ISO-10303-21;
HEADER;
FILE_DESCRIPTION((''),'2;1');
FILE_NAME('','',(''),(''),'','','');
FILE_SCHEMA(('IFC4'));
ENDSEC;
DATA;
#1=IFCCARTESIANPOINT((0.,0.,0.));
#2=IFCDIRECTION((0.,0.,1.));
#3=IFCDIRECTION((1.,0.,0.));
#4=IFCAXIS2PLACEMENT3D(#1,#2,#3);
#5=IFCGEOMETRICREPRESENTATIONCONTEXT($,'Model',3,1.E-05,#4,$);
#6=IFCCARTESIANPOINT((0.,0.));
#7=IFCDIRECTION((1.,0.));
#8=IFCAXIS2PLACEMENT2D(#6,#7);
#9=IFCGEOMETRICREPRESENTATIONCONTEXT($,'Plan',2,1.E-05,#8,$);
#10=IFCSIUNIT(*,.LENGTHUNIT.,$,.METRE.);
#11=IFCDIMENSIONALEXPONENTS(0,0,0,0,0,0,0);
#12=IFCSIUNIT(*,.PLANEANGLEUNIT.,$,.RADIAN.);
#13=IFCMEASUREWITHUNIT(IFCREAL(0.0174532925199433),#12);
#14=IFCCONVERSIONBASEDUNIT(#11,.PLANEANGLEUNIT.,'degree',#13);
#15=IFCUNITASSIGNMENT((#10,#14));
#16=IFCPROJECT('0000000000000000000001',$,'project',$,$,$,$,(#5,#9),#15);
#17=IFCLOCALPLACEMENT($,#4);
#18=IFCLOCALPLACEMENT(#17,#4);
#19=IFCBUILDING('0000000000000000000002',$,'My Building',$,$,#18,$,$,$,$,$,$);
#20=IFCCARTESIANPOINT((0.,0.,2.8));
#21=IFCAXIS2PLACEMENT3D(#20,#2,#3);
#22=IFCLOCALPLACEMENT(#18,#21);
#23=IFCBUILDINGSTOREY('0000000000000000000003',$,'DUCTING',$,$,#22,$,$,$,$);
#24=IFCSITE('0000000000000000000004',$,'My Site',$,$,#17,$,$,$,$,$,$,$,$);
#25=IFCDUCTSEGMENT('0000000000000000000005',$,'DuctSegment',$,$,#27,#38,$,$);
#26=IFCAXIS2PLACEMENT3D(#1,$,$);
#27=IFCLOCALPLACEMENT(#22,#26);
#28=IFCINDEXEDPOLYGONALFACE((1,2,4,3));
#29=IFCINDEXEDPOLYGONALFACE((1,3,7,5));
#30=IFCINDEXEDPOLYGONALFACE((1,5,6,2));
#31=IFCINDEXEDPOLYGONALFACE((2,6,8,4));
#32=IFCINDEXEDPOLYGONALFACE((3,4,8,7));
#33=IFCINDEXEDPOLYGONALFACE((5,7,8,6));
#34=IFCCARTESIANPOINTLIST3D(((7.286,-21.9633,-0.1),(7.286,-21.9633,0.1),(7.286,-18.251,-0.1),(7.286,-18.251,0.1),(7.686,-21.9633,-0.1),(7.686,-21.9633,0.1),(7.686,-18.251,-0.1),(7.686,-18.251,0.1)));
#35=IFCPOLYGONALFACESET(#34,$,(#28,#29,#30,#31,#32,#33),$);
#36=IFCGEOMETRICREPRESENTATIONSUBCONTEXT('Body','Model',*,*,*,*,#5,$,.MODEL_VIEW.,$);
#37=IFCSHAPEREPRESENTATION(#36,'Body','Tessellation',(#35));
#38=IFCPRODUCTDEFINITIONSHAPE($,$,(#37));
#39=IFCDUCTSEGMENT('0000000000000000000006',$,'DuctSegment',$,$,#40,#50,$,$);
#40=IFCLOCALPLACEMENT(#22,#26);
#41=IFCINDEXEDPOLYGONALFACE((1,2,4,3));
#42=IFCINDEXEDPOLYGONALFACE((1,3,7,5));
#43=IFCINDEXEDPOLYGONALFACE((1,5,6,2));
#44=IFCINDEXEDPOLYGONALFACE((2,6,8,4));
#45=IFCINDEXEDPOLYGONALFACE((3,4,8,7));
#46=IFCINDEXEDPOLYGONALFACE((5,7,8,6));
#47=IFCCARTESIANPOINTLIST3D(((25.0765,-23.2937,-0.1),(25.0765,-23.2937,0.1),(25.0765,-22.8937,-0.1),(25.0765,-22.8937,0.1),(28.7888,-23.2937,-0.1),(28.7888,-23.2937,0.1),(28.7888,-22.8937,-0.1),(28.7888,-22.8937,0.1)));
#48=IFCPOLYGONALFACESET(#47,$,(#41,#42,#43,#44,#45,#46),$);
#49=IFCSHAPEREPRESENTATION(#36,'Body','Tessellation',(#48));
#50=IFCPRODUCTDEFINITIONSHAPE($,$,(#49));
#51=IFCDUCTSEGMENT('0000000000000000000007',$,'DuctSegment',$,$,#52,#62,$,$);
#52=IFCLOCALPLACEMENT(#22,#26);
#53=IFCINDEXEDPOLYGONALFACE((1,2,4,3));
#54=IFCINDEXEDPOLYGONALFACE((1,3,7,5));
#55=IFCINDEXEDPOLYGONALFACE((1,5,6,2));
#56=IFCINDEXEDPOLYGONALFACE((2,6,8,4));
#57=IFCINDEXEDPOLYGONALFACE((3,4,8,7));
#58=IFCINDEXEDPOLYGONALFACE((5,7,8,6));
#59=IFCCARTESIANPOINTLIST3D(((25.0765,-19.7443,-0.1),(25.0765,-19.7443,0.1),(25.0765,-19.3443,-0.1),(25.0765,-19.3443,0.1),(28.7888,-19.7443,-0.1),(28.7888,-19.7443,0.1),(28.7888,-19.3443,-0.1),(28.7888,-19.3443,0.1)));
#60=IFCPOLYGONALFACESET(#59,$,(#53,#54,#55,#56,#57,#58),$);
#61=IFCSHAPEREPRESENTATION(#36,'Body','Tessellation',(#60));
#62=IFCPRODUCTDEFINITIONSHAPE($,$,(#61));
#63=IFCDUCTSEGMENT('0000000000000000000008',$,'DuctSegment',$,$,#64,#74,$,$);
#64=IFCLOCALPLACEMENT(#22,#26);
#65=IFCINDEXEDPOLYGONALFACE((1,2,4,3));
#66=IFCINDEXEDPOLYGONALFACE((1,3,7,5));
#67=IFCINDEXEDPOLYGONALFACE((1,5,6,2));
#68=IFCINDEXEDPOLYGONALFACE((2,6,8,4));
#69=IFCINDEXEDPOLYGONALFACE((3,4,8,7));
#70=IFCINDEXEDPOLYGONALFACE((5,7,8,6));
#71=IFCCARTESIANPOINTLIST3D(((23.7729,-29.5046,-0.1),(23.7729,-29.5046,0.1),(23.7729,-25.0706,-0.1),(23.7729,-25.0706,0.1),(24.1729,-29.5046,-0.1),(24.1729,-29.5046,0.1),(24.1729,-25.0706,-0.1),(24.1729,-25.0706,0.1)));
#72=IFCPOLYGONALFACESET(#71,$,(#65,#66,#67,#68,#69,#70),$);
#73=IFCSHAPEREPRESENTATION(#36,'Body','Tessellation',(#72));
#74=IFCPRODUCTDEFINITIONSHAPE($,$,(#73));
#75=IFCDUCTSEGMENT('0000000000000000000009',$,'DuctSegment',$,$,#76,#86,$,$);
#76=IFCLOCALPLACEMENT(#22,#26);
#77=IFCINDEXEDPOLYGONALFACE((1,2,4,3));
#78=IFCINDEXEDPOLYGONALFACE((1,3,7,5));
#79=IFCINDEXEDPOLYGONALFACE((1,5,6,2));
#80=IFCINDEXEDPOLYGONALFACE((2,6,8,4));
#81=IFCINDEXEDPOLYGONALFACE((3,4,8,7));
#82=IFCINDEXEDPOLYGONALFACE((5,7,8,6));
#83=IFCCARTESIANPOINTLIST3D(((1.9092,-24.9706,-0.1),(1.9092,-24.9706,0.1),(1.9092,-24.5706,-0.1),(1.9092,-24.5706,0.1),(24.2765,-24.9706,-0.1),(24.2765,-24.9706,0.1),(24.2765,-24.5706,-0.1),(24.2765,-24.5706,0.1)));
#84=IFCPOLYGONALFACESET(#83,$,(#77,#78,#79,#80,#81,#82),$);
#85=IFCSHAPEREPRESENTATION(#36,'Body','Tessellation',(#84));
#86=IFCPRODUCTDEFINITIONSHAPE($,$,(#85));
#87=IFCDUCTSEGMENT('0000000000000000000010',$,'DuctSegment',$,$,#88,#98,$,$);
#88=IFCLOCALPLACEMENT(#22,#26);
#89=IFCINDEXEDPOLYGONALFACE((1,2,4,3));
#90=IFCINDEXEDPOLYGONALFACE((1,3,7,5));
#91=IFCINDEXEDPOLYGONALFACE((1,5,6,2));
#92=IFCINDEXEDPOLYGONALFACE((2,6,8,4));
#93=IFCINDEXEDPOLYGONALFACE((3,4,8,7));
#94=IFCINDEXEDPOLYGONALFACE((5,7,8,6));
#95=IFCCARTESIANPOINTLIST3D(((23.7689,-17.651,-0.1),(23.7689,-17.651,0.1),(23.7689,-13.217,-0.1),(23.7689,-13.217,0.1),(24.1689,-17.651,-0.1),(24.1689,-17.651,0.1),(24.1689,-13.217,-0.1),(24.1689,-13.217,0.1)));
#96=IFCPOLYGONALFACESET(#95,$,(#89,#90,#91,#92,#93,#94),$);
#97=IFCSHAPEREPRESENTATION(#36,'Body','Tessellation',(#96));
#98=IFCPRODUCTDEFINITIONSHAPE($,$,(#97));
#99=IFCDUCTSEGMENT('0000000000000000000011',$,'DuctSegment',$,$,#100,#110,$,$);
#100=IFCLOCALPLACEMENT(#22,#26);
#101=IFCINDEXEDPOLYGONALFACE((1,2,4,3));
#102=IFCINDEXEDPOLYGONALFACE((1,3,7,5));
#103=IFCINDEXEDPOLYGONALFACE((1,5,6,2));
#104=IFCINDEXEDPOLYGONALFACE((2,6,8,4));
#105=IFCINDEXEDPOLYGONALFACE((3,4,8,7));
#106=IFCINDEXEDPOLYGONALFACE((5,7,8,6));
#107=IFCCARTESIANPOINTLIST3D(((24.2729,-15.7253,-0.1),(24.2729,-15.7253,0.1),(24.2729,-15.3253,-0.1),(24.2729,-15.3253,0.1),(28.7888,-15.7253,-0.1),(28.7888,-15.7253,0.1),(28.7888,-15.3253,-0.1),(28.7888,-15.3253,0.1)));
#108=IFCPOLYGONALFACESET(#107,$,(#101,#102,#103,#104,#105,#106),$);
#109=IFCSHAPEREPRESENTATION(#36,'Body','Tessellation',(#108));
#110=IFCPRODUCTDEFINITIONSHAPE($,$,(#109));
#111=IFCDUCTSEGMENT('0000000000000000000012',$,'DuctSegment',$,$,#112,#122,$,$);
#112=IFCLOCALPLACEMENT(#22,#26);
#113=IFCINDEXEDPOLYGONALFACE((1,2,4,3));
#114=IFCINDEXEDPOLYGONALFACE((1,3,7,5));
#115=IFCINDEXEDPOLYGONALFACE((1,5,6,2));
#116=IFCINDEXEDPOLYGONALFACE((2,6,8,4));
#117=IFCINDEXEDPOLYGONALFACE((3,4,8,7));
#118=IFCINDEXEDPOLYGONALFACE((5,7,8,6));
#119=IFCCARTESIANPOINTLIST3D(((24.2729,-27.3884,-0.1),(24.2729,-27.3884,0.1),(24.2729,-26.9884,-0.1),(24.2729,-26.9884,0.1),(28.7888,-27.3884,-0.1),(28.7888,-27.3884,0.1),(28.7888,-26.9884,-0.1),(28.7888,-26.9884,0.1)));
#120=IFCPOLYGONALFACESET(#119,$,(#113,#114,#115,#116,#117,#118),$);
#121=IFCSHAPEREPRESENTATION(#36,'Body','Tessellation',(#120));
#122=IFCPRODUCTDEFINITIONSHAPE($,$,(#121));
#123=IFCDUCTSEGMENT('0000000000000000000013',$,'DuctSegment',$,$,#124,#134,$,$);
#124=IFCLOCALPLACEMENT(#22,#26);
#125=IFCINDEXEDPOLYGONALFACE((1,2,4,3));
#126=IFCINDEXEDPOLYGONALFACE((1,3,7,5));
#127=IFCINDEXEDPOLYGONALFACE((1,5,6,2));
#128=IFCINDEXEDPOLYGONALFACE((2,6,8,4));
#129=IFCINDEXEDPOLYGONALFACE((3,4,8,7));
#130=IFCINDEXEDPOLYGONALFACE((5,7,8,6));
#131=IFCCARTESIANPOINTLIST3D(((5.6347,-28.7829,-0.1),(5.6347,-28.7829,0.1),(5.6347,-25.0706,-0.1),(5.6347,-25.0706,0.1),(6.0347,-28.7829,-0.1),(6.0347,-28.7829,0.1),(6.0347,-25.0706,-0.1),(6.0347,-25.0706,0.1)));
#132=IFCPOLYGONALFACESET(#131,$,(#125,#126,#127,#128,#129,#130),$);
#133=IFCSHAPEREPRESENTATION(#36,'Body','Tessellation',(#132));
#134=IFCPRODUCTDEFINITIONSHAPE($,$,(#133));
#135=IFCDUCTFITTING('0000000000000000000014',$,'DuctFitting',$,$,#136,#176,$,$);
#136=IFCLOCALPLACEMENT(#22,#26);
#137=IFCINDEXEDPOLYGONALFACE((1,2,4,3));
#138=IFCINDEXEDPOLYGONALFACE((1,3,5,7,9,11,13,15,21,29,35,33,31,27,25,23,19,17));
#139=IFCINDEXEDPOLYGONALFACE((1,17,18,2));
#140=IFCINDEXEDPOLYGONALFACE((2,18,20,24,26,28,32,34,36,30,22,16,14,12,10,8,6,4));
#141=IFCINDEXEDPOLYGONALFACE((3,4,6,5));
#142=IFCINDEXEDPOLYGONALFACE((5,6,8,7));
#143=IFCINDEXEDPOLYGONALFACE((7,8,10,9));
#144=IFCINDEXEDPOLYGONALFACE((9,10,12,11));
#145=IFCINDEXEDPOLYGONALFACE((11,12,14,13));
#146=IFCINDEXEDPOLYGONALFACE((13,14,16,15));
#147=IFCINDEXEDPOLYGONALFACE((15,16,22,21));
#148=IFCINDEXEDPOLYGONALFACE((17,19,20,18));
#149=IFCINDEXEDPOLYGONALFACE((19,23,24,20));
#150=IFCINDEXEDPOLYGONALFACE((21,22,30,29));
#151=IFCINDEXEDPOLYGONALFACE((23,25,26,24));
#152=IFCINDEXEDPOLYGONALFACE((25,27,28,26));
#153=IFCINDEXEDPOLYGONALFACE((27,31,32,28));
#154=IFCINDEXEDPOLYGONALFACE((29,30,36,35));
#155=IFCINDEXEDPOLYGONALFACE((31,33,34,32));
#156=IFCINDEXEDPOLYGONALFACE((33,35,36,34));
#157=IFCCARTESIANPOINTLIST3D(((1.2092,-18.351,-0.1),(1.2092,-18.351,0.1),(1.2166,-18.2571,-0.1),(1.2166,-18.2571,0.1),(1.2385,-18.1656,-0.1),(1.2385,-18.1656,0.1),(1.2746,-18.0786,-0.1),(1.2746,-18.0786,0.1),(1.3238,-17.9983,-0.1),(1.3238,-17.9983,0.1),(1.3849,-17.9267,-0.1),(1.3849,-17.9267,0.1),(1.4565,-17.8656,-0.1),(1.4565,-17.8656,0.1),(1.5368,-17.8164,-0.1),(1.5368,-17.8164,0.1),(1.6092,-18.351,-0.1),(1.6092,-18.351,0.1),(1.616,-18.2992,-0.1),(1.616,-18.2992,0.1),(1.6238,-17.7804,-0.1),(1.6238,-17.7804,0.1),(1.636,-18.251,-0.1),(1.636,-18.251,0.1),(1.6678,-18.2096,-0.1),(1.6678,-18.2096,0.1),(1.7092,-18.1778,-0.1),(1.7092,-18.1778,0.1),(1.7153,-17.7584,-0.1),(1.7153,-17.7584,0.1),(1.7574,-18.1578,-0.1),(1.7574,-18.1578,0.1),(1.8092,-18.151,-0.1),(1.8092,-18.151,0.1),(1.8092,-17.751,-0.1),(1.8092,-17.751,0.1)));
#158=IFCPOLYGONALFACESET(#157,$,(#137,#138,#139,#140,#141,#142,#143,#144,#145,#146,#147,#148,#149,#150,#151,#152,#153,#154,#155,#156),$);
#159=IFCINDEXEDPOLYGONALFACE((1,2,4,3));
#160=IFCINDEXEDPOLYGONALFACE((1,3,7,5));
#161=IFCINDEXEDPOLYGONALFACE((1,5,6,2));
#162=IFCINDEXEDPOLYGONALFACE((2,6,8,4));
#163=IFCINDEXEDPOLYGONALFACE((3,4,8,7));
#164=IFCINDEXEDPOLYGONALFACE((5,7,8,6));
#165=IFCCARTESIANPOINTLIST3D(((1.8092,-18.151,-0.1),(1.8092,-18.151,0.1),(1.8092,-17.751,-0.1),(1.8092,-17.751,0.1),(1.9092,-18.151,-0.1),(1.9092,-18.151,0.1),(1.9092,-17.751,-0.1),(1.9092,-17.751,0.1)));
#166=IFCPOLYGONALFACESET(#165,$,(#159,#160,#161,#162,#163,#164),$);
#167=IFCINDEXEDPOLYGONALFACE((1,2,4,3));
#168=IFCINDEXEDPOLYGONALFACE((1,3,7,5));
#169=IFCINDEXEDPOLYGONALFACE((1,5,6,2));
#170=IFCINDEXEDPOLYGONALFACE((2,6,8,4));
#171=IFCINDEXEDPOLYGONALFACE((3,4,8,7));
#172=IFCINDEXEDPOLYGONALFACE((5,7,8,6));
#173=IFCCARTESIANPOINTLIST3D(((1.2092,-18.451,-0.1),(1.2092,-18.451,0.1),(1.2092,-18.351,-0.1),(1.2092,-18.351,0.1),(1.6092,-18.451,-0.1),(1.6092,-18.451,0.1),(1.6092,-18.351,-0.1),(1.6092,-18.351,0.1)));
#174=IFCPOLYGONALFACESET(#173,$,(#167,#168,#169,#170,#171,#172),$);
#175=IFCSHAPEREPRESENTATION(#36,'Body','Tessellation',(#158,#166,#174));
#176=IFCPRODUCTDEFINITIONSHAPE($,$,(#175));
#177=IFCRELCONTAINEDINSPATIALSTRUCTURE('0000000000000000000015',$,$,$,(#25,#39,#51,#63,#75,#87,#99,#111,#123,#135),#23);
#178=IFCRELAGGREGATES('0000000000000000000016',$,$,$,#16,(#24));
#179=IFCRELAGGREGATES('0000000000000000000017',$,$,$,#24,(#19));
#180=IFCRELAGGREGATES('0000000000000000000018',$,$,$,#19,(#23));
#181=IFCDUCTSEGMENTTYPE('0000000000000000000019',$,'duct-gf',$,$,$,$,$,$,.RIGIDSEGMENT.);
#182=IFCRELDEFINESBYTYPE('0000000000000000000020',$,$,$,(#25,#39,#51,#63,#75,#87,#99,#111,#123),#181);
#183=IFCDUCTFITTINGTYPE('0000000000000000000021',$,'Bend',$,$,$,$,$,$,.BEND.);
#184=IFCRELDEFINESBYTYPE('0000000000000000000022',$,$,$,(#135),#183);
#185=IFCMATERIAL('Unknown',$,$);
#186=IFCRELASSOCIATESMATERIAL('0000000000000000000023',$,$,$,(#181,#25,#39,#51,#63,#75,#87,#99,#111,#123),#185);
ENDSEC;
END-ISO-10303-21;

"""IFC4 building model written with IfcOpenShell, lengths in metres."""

from ifc_helpers import new_model, entity, si_unit, converted_unit, frame, origin_with_axes, origin_2d_with_axis, place, context, subcontext, project, spatial, line, arc, indexed_curve, rectangle, outline, extrude, source, transform, mapped, material, material_profile, profile_set, profile_usage, type_object, type_shapes, element, save


model = new_model("IFC4")

# Units and contexts
model_context = context("Model", 3, precision=1e-05, world=origin_with_axes())
plan_context = context("Plan", 2, precision=1e-05, world=origin_2d_with_axis())
body_context = subcontext(model_context, "Body", "Model", "MODEL_VIEW")
ifc_project = project(units=[si_unit("LENGTHUNIT", "METRE"), converted_unit("PLANEANGLEUNIT", "degree", entity("IfcReal", 0.0174532925199433), si_unit("PLANEANGLEUNIT", "RADIAN"), dimensions=[0, 0, 0, 0, 0, 0, 0])], contexts=[model_context, plan_context])

# Site, building, storey
site_placement = place(None, origin_with_axes())
site = spatial("IfcSite", under=ifc_project, at=site_placement, Name="My Site")
building_placement = place(site_placement, origin_with_axes())
building = spatial("IfcBuilding", under=site, at=building_placement, Name="My Building")
storey_placement = place(building_placement, frame((0.0, 0.0, 2.8), z_axis=(0.0, 0.0, 1.0), x_axis=(1.0, 0.0, 0.0)))
storey = spatial("IfcBuildingStorey", under=building, at=storey_placement, Name="DUCTING")

# Duct segments
ifc_material = material(Name="Unknown")
ifc_material_profile = material_profile(ifc_material, rectangle(XDim=0.4, YDim=0.2))
ifc_profile_set = profile_set([ifc_material_profile])
duct_segment_type = type_object("IfcDuctSegmentType", Name="duct-gf", PredefinedType="RIGIDSEGMENT", material=ifc_profile_set)
ifc_profile_usage_1 = profile_usage(ifc_profile_set, cardinal=5)
duct_segment_1_placement = place(storey_placement, frame((7.486, -21.9633, 0.0), z_axis=(0.0, 1.0, 0.0), x_axis=(-1.0, 0.0, 0.0)))
element("IfcDuctSegment", 1, at=duct_segment_1_placement, inside=storey, type_object=duct_segment_type, material=ifc_profile_usage_1, Name="DuctSegment", context=body_context, shape_type="SweptSolid", body=[
    extrude(rectangle(XDim=0.4, YDim=0.2), origin_with_axes(), (0.0, 0.0, 1.0), 3.7122),
])
ifc_profile_usage_2 = profile_usage(ifc_profile_set, cardinal=5)
duct_segment_2_placement = place(storey_placement, frame((28.7888, -23.0937, 0.0), z_axis=(-1.0, 0.0, 0.0), x_axis=(0.0, -1.0, 0.0)))
element("IfcDuctSegment", 2, at=duct_segment_2_placement, inside=storey, type_object=duct_segment_type, material=ifc_profile_usage_2, Name="DuctSegment", context=body_context, shape_type="SweptSolid", body=[
    extrude(rectangle(XDim=0.4, YDim=0.2), origin_with_axes(), (0.0, 0.0, 1.0), 3.7122),
])
ifc_profile_usage_3 = profile_usage(ifc_profile_set, cardinal=5)
duct_segment_3_placement = place(storey_placement, frame((28.7888, -19.5443, 0.0), z_axis=(-1.0, 0.0, 0.0), x_axis=(0.0, -1.0, 0.0)))
element("IfcDuctSegment", 3, at=duct_segment_3_placement, inside=storey, type_object=duct_segment_type, material=ifc_profile_usage_3, Name="DuctSegment", context=body_context, shape_type="SweptSolid", body=[
    extrude(rectangle(XDim=0.4, YDim=0.2), origin_with_axes(), (0.0, 0.0, 1.0), 3.7122),
])
ifc_profile_usage_4 = profile_usage(ifc_profile_set, cardinal=5)
duct_segment_4_placement = place(storey_placement, frame((23.9729, -29.5046, 0.0), z_axis=(0.0, 1.0, 0.0), x_axis=(-1.0, 0.0, 0.0)))
element("IfcDuctSegment", 4, at=duct_segment_4_placement, inside=storey, type_object=duct_segment_type, material=ifc_profile_usage_4, Name="DuctSegment", context=body_context, shape_type="SweptSolid", body=[
    extrude(rectangle(XDim=0.4, YDim=0.2), origin_with_axes(), (0.0, 0.0, 1.0), 4.434),
])
ifc_profile_usage_5 = profile_usage(ifc_profile_set, cardinal=5)
duct_segment_5_placement = place(storey_placement, frame((1.9092, -24.7706, 0.0), z_axis=(1.0, -0.000001, 0.000001), x_axis=(0.000001, 1.0, 0.0)))
element("IfcDuctSegment", 5, at=duct_segment_5_placement, inside=storey, type_object=duct_segment_type, material=ifc_profile_usage_5, Name="DuctSegment", context=body_context, shape_type="SweptSolid", body=[
    extrude(rectangle(XDim=0.4, YDim=0.2), origin_with_axes(), (0.0, 0.0, 1.0), 22.3674),
])
ifc_profile_usage_6 = profile_usage(ifc_profile_set, cardinal=5)
duct_segment_6_placement = place(storey_placement, frame((23.9689, -13.217, 0.0), z_axis=(0.0, -1.0, 0.0), x_axis=(1.0, 0.0, 0.0)))
element("IfcDuctSegment", 6, at=duct_segment_6_placement, inside=storey, type_object=duct_segment_type, material=ifc_profile_usage_6, Name="DuctSegment", context=body_context, shape_type="SweptSolid", body=[
    extrude(rectangle(XDim=0.4, YDim=0.2), origin_with_axes(), (0.0, 0.0, 1.0), 4.434),
])
ifc_profile_usage_7 = profile_usage(ifc_profile_set, cardinal=5)
duct_segment_7_placement = place(storey_placement, frame((28.7888, -15.5253, 0.0), z_axis=(-1.0, 0.0, 0.0), x_axis=(0.0, -1.0, 0.0)))
element("IfcDuctSegment", 7, at=duct_segment_7_placement, inside=storey, type_object=duct_segment_type, material=ifc_profile_usage_7, Name="DuctSegment", context=body_context, shape_type="SweptSolid", body=[
    extrude(rectangle(XDim=0.4, YDim=0.2), origin_with_axes(), (0.0, 0.0, 1.0), 4.5159),
])
ifc_profile_usage_8 = profile_usage(ifc_profile_set, cardinal=5)
duct_segment_8_placement = place(storey_placement, frame((28.7888, -27.1884, 0.0), z_axis=(-1.0, 0.0, 0.0), x_axis=(0.0, -1.0, 0.0)))
element("IfcDuctSegment", 8, at=duct_segment_8_placement, inside=storey, type_object=duct_segment_type, material=ifc_profile_usage_8, Name="DuctSegment", context=body_context, shape_type="SweptSolid", body=[
    extrude(rectangle(XDim=0.4, YDim=0.2), origin_with_axes(), (0.0, 0.0, 1.0), 4.5159),
])
ifc_profile_usage_9 = profile_usage(ifc_profile_set, cardinal=5)
duct_segment_9_placement = place(storey_placement, frame((5.8347, -28.7829, 0.0), z_axis=(0.0, 1.0, 0.0), x_axis=(-1.0, 0.0, 0.0)))
element("IfcDuctSegment", 9, at=duct_segment_9_placement, inside=storey, type_object=duct_segment_type, material=ifc_profile_usage_9, Name="DuctSegment", context=body_context, shape_type="SweptSolid", body=[
    extrude(rectangle(XDim=0.4, YDim=0.2), origin_with_axes(), (0.0, 0.0, 1.0), 3.7122),
])

# Duct fitting
duct_fitting_type = type_object("IfcDuctFittingType", Name="Bend", PredefinedType="BEND")
shared_shape = source(origin_with_axes(), body_context, "Body", "SweptSolid", [
    extrude(outline(indexed_curve([(-0.2, 0.0), (-0.2586, -0.1414), (-0.4, -0.2), (-0.4, -0.6), (0.0243, -0.4243), (0.2, 0.0)], segments=[arc(1, 2, 3), line(3, 4), arc(4, 5, 6), line(6, 1)])), frame((0.0, -0.1, -0.1), z_axis=(0.0, -1.0, 0.0), x_axis=(1.0, 0.0, 0.0)), (0.0, 0.0, -1.0), 0.2),
    extrude(rectangle(XDim=0.4, YDim=0.2), origin_with_axes(), (0.0, 0.0, -1.0), 0.1),
    extrude(rectangle(XDim=0.4, YDim=0.2), frame((-0.4, 0.0, -0.5), z_axis=(-1.0, 0.0, 0.000001), x_axis=(-0.000001, 0.0, -1.0)), (0.0, 0.0, 1.0), 0.1),
])
type_shapes(duct_fitting_type, [shared_shape])
for number, where, z_axis, x_axis, name in (
    (10, (1.9092, -17.951, 0.0), (1.0, -0.000001, 0.000001), (0.000001, 1.0, 0.0), "DuctFitting"),
):
    element("IfcDuctFitting", number, at=place(storey_placement, frame(where, z_axis=z_axis, x_axis=x_axis)), inside=storey, type_object=duct_fitting_type, Name=name, context=body_context, shape_type="MappedRepresentation", body=[
        mapped(shared_shape, transform((0.0, 0.0, 0.0), x_axis=(1.0, 0.0, 0.0), y_axis=(0.0, 1.0, 0.0), z_axis=(0.0, 0.0, 1.0), scale=1.0)),
    ])

save(model, "model.ifc")
